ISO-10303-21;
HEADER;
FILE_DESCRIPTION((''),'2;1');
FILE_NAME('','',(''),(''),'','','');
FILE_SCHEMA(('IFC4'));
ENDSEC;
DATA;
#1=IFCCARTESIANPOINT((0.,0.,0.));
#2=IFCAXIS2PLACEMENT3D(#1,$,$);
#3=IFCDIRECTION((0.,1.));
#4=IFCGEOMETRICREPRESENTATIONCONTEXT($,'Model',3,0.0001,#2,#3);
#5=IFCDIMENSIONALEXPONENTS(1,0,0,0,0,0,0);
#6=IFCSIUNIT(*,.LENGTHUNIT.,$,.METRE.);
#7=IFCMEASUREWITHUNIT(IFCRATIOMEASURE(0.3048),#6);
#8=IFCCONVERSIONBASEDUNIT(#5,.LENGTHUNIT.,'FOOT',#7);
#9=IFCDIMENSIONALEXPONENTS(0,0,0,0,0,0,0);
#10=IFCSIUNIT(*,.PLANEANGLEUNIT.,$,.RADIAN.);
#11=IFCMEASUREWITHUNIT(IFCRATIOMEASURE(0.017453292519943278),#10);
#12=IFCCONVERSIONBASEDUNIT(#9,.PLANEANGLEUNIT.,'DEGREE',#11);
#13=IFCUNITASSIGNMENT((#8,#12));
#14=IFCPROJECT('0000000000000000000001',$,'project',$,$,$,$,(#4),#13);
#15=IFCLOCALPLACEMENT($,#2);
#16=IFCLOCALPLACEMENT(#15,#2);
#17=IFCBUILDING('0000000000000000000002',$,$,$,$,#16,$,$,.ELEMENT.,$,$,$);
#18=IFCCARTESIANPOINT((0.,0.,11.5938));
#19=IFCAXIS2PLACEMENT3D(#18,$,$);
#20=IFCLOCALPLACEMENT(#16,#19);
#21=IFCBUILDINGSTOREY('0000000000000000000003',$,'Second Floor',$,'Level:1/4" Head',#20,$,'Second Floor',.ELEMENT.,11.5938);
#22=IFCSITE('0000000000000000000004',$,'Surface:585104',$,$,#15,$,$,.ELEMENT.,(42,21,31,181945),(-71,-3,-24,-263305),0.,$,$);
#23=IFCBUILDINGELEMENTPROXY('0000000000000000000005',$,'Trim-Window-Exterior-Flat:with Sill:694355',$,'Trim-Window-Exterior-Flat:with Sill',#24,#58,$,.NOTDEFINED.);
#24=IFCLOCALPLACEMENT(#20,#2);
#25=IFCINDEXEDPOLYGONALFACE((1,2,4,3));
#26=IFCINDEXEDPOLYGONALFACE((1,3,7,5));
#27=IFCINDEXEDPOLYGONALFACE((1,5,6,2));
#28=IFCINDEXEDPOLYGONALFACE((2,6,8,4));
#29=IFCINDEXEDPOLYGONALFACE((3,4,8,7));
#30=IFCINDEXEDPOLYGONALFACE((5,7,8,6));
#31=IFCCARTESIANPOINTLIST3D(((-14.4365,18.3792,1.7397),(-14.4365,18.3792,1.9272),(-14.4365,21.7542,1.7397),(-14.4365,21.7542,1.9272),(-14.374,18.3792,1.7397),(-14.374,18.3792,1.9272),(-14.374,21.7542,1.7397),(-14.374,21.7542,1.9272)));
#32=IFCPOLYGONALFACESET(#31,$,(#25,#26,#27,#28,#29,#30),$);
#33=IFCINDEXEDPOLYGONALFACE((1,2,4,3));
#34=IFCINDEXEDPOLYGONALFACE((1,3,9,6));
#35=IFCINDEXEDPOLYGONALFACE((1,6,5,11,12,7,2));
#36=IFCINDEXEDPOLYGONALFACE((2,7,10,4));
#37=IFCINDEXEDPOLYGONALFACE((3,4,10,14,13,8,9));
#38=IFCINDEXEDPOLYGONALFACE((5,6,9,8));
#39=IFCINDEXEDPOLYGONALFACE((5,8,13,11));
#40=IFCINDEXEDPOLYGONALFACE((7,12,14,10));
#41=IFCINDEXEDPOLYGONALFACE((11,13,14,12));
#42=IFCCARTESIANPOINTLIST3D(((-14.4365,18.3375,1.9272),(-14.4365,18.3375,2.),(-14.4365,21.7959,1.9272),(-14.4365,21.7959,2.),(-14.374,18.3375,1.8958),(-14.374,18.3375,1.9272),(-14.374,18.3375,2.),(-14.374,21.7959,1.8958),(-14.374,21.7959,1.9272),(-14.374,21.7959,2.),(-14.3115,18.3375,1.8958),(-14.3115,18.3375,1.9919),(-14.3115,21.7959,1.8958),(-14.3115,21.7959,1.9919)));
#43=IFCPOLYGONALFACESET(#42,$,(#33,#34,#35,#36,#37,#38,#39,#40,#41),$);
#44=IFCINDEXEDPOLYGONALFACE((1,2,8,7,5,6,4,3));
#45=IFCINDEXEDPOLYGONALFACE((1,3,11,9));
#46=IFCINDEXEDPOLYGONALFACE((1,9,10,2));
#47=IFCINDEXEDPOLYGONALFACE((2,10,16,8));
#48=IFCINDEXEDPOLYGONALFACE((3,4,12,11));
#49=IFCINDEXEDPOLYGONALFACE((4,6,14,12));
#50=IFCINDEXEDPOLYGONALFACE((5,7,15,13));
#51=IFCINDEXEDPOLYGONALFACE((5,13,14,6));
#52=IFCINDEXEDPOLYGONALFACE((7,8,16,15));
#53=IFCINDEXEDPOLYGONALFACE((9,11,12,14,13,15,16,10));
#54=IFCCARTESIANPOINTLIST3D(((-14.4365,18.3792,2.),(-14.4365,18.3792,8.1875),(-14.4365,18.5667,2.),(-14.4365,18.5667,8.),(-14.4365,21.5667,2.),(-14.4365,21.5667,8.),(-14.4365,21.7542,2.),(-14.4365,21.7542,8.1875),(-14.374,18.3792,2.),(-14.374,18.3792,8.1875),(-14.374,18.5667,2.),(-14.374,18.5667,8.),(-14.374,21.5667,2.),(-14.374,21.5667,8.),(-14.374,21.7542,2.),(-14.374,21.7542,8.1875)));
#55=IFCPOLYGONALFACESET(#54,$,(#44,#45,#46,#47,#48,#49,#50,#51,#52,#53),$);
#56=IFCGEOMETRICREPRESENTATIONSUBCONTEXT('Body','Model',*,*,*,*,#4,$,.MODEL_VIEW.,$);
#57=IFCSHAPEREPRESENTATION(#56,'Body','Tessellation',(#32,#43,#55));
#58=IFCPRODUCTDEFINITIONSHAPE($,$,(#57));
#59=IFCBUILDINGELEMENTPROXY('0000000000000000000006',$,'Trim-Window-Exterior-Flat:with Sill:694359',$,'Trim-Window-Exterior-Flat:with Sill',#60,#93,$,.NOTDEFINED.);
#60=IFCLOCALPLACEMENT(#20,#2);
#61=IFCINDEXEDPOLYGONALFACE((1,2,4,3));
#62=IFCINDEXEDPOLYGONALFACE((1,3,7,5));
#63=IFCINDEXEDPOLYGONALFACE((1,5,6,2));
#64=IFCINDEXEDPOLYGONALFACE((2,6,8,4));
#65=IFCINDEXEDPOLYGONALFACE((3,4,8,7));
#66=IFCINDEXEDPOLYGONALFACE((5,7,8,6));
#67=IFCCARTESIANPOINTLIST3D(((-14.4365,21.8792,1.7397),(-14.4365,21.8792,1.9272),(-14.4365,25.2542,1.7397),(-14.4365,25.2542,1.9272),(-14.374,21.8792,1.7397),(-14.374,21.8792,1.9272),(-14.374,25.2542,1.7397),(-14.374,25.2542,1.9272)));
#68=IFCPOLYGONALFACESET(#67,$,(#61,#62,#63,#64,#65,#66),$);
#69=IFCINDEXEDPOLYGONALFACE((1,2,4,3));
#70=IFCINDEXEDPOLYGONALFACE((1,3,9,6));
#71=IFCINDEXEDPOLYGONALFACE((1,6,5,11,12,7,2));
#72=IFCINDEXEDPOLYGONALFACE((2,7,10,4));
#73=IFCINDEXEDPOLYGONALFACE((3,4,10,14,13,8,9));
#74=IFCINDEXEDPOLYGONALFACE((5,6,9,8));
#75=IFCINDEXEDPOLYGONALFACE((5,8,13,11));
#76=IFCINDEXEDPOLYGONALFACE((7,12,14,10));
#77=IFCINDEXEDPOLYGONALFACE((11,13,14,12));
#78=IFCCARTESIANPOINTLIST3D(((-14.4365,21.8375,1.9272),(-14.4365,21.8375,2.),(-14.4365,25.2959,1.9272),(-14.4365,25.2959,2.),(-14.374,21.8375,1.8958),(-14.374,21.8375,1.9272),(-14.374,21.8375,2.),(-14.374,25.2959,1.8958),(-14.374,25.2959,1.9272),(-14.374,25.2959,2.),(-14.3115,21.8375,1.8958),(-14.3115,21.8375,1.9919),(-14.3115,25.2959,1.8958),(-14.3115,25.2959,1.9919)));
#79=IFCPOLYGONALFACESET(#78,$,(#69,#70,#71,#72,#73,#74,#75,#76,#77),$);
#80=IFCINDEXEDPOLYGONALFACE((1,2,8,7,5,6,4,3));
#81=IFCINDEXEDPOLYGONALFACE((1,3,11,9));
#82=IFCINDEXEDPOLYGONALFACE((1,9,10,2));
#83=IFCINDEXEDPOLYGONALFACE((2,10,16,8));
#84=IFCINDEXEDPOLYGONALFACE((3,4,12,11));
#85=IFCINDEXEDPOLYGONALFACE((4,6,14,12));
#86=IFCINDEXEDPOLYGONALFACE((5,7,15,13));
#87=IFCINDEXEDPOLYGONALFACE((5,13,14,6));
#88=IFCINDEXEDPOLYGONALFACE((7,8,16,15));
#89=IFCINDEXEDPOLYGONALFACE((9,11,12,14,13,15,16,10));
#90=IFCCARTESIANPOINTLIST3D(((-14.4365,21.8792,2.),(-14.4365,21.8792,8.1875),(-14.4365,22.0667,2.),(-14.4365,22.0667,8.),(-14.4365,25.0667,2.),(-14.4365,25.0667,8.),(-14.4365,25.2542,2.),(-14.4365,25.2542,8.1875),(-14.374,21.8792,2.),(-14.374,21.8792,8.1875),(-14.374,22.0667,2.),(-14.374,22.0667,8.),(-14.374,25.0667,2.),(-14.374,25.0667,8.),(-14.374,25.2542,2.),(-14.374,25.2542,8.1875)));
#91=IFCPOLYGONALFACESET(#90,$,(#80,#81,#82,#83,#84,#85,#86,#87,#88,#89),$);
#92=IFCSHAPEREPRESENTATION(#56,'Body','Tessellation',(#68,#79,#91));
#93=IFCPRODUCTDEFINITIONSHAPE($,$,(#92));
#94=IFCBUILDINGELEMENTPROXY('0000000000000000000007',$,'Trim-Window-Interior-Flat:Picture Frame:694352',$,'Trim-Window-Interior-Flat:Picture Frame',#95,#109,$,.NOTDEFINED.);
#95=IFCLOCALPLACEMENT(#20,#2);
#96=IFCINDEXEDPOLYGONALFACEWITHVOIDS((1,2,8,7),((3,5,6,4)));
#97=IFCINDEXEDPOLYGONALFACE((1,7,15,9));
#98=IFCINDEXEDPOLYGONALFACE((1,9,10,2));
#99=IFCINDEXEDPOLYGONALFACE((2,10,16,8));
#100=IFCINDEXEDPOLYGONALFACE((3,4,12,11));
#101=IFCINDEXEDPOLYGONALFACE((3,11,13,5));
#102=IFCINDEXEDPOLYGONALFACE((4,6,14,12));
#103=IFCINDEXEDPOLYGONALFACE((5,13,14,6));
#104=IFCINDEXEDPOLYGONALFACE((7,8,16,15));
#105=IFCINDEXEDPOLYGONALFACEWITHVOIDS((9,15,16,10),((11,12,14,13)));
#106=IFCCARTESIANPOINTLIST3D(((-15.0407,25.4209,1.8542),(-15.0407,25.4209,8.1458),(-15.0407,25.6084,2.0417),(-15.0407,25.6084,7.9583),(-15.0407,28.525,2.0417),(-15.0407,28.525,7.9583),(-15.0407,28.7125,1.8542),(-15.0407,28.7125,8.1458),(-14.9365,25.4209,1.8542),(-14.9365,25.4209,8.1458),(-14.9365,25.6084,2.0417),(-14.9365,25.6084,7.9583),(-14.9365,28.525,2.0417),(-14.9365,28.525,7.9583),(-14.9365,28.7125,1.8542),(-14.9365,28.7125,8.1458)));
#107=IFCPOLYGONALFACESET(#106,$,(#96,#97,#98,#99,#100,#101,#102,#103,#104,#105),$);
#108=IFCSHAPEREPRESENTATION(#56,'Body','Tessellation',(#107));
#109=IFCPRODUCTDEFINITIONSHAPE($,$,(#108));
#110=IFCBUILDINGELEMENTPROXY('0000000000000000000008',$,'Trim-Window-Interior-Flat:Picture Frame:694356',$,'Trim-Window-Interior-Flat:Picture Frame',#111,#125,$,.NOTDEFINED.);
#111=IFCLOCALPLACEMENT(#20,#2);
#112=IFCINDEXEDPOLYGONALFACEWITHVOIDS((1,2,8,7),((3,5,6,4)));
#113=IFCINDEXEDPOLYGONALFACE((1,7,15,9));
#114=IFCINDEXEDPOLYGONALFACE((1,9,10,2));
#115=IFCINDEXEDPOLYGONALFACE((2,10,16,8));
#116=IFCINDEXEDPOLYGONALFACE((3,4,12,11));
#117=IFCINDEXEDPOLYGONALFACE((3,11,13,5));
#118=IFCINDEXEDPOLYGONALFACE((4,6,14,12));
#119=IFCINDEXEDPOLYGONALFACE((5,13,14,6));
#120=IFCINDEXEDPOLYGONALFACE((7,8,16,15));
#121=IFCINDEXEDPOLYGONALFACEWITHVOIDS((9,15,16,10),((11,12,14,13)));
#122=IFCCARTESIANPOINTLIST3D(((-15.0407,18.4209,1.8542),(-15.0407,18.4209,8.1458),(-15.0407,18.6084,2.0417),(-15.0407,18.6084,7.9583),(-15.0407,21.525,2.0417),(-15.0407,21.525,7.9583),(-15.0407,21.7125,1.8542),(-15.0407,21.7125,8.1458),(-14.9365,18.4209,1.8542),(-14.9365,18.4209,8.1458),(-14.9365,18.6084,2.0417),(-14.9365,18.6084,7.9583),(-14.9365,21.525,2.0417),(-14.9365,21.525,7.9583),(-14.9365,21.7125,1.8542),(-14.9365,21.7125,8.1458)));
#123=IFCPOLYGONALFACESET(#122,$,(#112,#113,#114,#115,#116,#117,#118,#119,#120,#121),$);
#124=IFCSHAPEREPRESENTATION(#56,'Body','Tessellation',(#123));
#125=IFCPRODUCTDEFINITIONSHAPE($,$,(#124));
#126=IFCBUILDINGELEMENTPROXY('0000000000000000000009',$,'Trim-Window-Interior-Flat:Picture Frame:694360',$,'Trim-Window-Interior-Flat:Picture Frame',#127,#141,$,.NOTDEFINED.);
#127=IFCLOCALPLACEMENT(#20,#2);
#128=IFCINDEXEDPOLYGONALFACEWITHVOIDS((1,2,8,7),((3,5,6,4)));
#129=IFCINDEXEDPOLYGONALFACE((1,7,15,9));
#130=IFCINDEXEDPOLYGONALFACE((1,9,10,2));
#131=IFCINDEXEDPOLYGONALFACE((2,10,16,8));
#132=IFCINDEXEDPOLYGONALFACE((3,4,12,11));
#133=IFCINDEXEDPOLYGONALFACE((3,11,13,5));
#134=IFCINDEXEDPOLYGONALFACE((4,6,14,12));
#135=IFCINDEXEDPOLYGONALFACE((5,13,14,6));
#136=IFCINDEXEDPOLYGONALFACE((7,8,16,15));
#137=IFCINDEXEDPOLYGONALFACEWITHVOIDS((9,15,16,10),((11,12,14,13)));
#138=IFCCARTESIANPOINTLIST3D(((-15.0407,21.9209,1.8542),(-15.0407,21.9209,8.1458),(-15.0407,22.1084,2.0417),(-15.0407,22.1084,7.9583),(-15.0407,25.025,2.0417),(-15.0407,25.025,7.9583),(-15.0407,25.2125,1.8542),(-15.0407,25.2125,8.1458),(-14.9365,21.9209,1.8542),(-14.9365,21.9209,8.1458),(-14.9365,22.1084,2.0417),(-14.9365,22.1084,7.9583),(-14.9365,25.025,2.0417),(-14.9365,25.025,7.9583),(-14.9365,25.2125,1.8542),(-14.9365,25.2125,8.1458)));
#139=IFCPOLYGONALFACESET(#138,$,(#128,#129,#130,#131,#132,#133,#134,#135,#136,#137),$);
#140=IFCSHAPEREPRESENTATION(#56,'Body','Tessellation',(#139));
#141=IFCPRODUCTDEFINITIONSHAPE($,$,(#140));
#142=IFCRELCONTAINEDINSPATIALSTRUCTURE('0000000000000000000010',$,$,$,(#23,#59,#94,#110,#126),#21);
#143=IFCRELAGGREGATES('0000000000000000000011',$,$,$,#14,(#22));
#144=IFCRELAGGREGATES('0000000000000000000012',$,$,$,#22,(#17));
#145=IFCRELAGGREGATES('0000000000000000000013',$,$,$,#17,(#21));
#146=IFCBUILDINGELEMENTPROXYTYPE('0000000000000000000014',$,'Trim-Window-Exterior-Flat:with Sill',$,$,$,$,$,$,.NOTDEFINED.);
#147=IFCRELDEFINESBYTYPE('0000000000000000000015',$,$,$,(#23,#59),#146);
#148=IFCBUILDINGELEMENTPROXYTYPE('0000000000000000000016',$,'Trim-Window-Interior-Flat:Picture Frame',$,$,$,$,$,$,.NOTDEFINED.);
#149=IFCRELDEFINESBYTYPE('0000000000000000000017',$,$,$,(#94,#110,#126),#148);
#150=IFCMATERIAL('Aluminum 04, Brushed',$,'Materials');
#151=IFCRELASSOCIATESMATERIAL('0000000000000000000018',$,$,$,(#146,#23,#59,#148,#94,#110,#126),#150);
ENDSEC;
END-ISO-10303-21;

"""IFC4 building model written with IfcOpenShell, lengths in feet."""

from ifc_helpers import new_model, entity, si_unit, converted_unit, direction, frame, origin, place, context, subcontext, project, spatial, indexed_curve, outline, extrude, source, transform, mapped, material, type_object, type_shapes, element, save


model = new_model("IFC4")

# Units and contexts
model_context = context("Model", 3, precision=0.0001, world=origin(), true_north=direction((0.0, 1.0)))
body_context = subcontext(model_context, "Body", "Model", "MODEL_VIEW")
ifc_project = project(units=[converted_unit("LENGTHUNIT", "FOOT", entity("IfcRatioMeasure", 0.3048), si_unit("LENGTHUNIT", "METRE"), dimensions=[1, 0, 0, 0, 0, 0, 0]), converted_unit("PLANEANGLEUNIT", "DEGREE", entity("IfcRatioMeasure", 0.017453292519943278), si_unit("PLANEANGLEUNIT", "RADIAN"), dimensions=[0, 0, 0, 0, 0, 0, 0])], contexts=[model_context])

# Site, building, storey
site_placement = place(None, origin())
site = spatial("IfcSite", under=ifc_project, at=site_placement, Name="Surface:585104", CompositionType="ELEMENT", RefLatitude=(42, 21, 31, 181945), RefLongitude=(-71, -3, -24, -263305), RefElevation=0.0)
building_placement = place(site_placement, origin())
building = spatial("IfcBuilding", under=site, at=building_placement, CompositionType="ELEMENT")
storey_placement = place(building_placement, frame((0.0, 0.0, 11.5938)))
storey = spatial("IfcBuildingStorey", under=building, at=storey_placement, Name="Second Floor", ObjectType="Level:1/4\" Head", LongName="Second Floor", CompositionType="ELEMENT", Elevation=11.5938)

# Building element proxies
ifc_material_1 = material(Name="Aluminum 04, Brushed", Category="Materials")
building_element_proxy_type_1 = type_object("IfcBuildingElementProxyType", Name="Trim-Window-Exterior-Flat:with Sill", PredefinedType="NOTDEFINED", material=ifc_material_1)
shared_shape_1 = source(origin(), body_context, "Body", "SweptSolid", [
    extrude(outline(indexed_curve([(-1.6875, -0.0938), (1.6875, -0.0938), (1.6875, 0.0938), (-1.6875, 0.0938), (-1.6875, -0.0938)], self_intersect=False)), frame((0.0, -6.1665, 0.0), z_axis=(0.0, 0.0, 1.0), x_axis=(-1.0, 0.0, 0.0)), (0.0, 0.0, 1.0), 0.0625),
    extrude(outline(indexed_curve([(-0.0625, -0.0525), (0.0, -0.0525), (0.0, -0.0211), (0.0625, -0.0211), (0.0625, 0.0517), (0.0, 0.0517), (-0.0625, 0.0436), (-0.0625, -0.0525)], self_intersect=False)), frame((-1.7292, -6.0517, 0.0625), z_axis=(1.0, 0.0, 0.0), x_axis=(0.0, 0.0, -1.0)), (0.0, 0.0, 1.0), 3.4583),
    extrude(outline(indexed_curve([(-3.1406, -1.6875), (3.0469, -1.6875), (3.0469, -1.5), (-2.9531, -1.5), (-2.9531, 1.5), (3.0469, 1.5), (3.0469, 1.6875), (-3.1406, 1.6875), (-3.1406, -1.6875)], self_intersect=False)), frame((0.0, -2.9531, 0.0), z_axis=(0.0, 0.0, 1.0), x_axis=(0.0, -1.0, 0.0)), (0.0, 0.0, 1.0), 0.0625),
])
type_shapes(building_element_proxy_type_1, [shared_shape_1])
for number, where, z_axis, x_axis, name in (
    (1, (-14.4365, 20.0667, 8.0), (1.0, 0.0, 0.0), (0.0, 1.0, 0.0), "Trim-Window-Exterior-Flat:with Sill:694355"),
    (2, (-14.4365, 23.5667, 8.0), (1.0, 0.0, 0.0), (0.0, 1.0, 0.0), "Trim-Window-Exterior-Flat:with Sill:694359"),
):
    element("IfcBuildingElementProxy", number, at=place(storey_placement, frame(where, z_axis=z_axis, x_axis=x_axis)), inside=storey, type_object=building_element_proxy_type_1, material=ifc_material_1, Name=name, ObjectType="Trim-Window-Exterior-Flat:with Sill", PredefinedType="NOTDEFINED", context=body_context, shape_type="MappedRepresentation", body=[
        mapped(shared_shape_1, transform((0.0, 0.0, 0.0), scale=1.0)),
    ])
building_element_proxy_type_2 = type_object("IfcBuildingElementProxyType", Name="Trim-Window-Interior-Flat:Picture Frame", PredefinedType="NOTDEFINED", material=ifc_material_1)
shared_shape_2 = source(origin(), body_context, "Body", "SweptSolid", [
    extrude(outline(indexed_curve([(-1.6458, -3.1458), (1.6458, -3.1458), (1.6458, 3.1458), (-1.6458, 3.1458), (-1.6458, -3.1458)], self_intersect=False), holes=[indexed_curve([(-1.4583, -2.9583), (-1.4583, 2.9583), (1.4583, 2.9583), (1.4583, -2.9583), (-1.4583, -2.9583)], self_intersect=False)]), frame((0.0, -3.0, 0.0), z_axis=(0.0, 0.0, 1.0), x_axis=(-1.0, 0.0, 0.0)), (0.0, 0.0, 1.0), 0.1042),
])
type_shapes(building_element_proxy_type_2, [shared_shape_2])
for number, where, z_axis, x_axis, name in (
    (3, (-14.9365, 27.0667, 8.0), (-1.0, 0.0, 0.0), (0.0, -1.0, 0.0), "Trim-Window-Interior-Flat:Picture Frame:694352"),
    (4, (-14.9365, 20.0667, 8.0), (-1.0, 0.0, 0.0), (0.0, -1.0, 0.0), "Trim-Window-Interior-Flat:Picture Frame:694356"),
    (5, (-14.9365, 23.5667, 8.0), (-1.0, 0.0, 0.0), (0.0, -1.0, 0.0), "Trim-Window-Interior-Flat:Picture Frame:694360"),
):
    element("IfcBuildingElementProxy", number, at=place(storey_placement, frame(where, z_axis=z_axis, x_axis=x_axis)), inside=storey, type_object=building_element_proxy_type_2, material=ifc_material_1, Name=name, ObjectType="Trim-Window-Interior-Flat:Picture Frame", PredefinedType="NOTDEFINED", context=body_context, shape_type="MappedRepresentation", body=[
        mapped(shared_shape_2, transform((0.0, 0.0, 0.0), scale=1.0)),
    ])

save(model, "model.ifc")
